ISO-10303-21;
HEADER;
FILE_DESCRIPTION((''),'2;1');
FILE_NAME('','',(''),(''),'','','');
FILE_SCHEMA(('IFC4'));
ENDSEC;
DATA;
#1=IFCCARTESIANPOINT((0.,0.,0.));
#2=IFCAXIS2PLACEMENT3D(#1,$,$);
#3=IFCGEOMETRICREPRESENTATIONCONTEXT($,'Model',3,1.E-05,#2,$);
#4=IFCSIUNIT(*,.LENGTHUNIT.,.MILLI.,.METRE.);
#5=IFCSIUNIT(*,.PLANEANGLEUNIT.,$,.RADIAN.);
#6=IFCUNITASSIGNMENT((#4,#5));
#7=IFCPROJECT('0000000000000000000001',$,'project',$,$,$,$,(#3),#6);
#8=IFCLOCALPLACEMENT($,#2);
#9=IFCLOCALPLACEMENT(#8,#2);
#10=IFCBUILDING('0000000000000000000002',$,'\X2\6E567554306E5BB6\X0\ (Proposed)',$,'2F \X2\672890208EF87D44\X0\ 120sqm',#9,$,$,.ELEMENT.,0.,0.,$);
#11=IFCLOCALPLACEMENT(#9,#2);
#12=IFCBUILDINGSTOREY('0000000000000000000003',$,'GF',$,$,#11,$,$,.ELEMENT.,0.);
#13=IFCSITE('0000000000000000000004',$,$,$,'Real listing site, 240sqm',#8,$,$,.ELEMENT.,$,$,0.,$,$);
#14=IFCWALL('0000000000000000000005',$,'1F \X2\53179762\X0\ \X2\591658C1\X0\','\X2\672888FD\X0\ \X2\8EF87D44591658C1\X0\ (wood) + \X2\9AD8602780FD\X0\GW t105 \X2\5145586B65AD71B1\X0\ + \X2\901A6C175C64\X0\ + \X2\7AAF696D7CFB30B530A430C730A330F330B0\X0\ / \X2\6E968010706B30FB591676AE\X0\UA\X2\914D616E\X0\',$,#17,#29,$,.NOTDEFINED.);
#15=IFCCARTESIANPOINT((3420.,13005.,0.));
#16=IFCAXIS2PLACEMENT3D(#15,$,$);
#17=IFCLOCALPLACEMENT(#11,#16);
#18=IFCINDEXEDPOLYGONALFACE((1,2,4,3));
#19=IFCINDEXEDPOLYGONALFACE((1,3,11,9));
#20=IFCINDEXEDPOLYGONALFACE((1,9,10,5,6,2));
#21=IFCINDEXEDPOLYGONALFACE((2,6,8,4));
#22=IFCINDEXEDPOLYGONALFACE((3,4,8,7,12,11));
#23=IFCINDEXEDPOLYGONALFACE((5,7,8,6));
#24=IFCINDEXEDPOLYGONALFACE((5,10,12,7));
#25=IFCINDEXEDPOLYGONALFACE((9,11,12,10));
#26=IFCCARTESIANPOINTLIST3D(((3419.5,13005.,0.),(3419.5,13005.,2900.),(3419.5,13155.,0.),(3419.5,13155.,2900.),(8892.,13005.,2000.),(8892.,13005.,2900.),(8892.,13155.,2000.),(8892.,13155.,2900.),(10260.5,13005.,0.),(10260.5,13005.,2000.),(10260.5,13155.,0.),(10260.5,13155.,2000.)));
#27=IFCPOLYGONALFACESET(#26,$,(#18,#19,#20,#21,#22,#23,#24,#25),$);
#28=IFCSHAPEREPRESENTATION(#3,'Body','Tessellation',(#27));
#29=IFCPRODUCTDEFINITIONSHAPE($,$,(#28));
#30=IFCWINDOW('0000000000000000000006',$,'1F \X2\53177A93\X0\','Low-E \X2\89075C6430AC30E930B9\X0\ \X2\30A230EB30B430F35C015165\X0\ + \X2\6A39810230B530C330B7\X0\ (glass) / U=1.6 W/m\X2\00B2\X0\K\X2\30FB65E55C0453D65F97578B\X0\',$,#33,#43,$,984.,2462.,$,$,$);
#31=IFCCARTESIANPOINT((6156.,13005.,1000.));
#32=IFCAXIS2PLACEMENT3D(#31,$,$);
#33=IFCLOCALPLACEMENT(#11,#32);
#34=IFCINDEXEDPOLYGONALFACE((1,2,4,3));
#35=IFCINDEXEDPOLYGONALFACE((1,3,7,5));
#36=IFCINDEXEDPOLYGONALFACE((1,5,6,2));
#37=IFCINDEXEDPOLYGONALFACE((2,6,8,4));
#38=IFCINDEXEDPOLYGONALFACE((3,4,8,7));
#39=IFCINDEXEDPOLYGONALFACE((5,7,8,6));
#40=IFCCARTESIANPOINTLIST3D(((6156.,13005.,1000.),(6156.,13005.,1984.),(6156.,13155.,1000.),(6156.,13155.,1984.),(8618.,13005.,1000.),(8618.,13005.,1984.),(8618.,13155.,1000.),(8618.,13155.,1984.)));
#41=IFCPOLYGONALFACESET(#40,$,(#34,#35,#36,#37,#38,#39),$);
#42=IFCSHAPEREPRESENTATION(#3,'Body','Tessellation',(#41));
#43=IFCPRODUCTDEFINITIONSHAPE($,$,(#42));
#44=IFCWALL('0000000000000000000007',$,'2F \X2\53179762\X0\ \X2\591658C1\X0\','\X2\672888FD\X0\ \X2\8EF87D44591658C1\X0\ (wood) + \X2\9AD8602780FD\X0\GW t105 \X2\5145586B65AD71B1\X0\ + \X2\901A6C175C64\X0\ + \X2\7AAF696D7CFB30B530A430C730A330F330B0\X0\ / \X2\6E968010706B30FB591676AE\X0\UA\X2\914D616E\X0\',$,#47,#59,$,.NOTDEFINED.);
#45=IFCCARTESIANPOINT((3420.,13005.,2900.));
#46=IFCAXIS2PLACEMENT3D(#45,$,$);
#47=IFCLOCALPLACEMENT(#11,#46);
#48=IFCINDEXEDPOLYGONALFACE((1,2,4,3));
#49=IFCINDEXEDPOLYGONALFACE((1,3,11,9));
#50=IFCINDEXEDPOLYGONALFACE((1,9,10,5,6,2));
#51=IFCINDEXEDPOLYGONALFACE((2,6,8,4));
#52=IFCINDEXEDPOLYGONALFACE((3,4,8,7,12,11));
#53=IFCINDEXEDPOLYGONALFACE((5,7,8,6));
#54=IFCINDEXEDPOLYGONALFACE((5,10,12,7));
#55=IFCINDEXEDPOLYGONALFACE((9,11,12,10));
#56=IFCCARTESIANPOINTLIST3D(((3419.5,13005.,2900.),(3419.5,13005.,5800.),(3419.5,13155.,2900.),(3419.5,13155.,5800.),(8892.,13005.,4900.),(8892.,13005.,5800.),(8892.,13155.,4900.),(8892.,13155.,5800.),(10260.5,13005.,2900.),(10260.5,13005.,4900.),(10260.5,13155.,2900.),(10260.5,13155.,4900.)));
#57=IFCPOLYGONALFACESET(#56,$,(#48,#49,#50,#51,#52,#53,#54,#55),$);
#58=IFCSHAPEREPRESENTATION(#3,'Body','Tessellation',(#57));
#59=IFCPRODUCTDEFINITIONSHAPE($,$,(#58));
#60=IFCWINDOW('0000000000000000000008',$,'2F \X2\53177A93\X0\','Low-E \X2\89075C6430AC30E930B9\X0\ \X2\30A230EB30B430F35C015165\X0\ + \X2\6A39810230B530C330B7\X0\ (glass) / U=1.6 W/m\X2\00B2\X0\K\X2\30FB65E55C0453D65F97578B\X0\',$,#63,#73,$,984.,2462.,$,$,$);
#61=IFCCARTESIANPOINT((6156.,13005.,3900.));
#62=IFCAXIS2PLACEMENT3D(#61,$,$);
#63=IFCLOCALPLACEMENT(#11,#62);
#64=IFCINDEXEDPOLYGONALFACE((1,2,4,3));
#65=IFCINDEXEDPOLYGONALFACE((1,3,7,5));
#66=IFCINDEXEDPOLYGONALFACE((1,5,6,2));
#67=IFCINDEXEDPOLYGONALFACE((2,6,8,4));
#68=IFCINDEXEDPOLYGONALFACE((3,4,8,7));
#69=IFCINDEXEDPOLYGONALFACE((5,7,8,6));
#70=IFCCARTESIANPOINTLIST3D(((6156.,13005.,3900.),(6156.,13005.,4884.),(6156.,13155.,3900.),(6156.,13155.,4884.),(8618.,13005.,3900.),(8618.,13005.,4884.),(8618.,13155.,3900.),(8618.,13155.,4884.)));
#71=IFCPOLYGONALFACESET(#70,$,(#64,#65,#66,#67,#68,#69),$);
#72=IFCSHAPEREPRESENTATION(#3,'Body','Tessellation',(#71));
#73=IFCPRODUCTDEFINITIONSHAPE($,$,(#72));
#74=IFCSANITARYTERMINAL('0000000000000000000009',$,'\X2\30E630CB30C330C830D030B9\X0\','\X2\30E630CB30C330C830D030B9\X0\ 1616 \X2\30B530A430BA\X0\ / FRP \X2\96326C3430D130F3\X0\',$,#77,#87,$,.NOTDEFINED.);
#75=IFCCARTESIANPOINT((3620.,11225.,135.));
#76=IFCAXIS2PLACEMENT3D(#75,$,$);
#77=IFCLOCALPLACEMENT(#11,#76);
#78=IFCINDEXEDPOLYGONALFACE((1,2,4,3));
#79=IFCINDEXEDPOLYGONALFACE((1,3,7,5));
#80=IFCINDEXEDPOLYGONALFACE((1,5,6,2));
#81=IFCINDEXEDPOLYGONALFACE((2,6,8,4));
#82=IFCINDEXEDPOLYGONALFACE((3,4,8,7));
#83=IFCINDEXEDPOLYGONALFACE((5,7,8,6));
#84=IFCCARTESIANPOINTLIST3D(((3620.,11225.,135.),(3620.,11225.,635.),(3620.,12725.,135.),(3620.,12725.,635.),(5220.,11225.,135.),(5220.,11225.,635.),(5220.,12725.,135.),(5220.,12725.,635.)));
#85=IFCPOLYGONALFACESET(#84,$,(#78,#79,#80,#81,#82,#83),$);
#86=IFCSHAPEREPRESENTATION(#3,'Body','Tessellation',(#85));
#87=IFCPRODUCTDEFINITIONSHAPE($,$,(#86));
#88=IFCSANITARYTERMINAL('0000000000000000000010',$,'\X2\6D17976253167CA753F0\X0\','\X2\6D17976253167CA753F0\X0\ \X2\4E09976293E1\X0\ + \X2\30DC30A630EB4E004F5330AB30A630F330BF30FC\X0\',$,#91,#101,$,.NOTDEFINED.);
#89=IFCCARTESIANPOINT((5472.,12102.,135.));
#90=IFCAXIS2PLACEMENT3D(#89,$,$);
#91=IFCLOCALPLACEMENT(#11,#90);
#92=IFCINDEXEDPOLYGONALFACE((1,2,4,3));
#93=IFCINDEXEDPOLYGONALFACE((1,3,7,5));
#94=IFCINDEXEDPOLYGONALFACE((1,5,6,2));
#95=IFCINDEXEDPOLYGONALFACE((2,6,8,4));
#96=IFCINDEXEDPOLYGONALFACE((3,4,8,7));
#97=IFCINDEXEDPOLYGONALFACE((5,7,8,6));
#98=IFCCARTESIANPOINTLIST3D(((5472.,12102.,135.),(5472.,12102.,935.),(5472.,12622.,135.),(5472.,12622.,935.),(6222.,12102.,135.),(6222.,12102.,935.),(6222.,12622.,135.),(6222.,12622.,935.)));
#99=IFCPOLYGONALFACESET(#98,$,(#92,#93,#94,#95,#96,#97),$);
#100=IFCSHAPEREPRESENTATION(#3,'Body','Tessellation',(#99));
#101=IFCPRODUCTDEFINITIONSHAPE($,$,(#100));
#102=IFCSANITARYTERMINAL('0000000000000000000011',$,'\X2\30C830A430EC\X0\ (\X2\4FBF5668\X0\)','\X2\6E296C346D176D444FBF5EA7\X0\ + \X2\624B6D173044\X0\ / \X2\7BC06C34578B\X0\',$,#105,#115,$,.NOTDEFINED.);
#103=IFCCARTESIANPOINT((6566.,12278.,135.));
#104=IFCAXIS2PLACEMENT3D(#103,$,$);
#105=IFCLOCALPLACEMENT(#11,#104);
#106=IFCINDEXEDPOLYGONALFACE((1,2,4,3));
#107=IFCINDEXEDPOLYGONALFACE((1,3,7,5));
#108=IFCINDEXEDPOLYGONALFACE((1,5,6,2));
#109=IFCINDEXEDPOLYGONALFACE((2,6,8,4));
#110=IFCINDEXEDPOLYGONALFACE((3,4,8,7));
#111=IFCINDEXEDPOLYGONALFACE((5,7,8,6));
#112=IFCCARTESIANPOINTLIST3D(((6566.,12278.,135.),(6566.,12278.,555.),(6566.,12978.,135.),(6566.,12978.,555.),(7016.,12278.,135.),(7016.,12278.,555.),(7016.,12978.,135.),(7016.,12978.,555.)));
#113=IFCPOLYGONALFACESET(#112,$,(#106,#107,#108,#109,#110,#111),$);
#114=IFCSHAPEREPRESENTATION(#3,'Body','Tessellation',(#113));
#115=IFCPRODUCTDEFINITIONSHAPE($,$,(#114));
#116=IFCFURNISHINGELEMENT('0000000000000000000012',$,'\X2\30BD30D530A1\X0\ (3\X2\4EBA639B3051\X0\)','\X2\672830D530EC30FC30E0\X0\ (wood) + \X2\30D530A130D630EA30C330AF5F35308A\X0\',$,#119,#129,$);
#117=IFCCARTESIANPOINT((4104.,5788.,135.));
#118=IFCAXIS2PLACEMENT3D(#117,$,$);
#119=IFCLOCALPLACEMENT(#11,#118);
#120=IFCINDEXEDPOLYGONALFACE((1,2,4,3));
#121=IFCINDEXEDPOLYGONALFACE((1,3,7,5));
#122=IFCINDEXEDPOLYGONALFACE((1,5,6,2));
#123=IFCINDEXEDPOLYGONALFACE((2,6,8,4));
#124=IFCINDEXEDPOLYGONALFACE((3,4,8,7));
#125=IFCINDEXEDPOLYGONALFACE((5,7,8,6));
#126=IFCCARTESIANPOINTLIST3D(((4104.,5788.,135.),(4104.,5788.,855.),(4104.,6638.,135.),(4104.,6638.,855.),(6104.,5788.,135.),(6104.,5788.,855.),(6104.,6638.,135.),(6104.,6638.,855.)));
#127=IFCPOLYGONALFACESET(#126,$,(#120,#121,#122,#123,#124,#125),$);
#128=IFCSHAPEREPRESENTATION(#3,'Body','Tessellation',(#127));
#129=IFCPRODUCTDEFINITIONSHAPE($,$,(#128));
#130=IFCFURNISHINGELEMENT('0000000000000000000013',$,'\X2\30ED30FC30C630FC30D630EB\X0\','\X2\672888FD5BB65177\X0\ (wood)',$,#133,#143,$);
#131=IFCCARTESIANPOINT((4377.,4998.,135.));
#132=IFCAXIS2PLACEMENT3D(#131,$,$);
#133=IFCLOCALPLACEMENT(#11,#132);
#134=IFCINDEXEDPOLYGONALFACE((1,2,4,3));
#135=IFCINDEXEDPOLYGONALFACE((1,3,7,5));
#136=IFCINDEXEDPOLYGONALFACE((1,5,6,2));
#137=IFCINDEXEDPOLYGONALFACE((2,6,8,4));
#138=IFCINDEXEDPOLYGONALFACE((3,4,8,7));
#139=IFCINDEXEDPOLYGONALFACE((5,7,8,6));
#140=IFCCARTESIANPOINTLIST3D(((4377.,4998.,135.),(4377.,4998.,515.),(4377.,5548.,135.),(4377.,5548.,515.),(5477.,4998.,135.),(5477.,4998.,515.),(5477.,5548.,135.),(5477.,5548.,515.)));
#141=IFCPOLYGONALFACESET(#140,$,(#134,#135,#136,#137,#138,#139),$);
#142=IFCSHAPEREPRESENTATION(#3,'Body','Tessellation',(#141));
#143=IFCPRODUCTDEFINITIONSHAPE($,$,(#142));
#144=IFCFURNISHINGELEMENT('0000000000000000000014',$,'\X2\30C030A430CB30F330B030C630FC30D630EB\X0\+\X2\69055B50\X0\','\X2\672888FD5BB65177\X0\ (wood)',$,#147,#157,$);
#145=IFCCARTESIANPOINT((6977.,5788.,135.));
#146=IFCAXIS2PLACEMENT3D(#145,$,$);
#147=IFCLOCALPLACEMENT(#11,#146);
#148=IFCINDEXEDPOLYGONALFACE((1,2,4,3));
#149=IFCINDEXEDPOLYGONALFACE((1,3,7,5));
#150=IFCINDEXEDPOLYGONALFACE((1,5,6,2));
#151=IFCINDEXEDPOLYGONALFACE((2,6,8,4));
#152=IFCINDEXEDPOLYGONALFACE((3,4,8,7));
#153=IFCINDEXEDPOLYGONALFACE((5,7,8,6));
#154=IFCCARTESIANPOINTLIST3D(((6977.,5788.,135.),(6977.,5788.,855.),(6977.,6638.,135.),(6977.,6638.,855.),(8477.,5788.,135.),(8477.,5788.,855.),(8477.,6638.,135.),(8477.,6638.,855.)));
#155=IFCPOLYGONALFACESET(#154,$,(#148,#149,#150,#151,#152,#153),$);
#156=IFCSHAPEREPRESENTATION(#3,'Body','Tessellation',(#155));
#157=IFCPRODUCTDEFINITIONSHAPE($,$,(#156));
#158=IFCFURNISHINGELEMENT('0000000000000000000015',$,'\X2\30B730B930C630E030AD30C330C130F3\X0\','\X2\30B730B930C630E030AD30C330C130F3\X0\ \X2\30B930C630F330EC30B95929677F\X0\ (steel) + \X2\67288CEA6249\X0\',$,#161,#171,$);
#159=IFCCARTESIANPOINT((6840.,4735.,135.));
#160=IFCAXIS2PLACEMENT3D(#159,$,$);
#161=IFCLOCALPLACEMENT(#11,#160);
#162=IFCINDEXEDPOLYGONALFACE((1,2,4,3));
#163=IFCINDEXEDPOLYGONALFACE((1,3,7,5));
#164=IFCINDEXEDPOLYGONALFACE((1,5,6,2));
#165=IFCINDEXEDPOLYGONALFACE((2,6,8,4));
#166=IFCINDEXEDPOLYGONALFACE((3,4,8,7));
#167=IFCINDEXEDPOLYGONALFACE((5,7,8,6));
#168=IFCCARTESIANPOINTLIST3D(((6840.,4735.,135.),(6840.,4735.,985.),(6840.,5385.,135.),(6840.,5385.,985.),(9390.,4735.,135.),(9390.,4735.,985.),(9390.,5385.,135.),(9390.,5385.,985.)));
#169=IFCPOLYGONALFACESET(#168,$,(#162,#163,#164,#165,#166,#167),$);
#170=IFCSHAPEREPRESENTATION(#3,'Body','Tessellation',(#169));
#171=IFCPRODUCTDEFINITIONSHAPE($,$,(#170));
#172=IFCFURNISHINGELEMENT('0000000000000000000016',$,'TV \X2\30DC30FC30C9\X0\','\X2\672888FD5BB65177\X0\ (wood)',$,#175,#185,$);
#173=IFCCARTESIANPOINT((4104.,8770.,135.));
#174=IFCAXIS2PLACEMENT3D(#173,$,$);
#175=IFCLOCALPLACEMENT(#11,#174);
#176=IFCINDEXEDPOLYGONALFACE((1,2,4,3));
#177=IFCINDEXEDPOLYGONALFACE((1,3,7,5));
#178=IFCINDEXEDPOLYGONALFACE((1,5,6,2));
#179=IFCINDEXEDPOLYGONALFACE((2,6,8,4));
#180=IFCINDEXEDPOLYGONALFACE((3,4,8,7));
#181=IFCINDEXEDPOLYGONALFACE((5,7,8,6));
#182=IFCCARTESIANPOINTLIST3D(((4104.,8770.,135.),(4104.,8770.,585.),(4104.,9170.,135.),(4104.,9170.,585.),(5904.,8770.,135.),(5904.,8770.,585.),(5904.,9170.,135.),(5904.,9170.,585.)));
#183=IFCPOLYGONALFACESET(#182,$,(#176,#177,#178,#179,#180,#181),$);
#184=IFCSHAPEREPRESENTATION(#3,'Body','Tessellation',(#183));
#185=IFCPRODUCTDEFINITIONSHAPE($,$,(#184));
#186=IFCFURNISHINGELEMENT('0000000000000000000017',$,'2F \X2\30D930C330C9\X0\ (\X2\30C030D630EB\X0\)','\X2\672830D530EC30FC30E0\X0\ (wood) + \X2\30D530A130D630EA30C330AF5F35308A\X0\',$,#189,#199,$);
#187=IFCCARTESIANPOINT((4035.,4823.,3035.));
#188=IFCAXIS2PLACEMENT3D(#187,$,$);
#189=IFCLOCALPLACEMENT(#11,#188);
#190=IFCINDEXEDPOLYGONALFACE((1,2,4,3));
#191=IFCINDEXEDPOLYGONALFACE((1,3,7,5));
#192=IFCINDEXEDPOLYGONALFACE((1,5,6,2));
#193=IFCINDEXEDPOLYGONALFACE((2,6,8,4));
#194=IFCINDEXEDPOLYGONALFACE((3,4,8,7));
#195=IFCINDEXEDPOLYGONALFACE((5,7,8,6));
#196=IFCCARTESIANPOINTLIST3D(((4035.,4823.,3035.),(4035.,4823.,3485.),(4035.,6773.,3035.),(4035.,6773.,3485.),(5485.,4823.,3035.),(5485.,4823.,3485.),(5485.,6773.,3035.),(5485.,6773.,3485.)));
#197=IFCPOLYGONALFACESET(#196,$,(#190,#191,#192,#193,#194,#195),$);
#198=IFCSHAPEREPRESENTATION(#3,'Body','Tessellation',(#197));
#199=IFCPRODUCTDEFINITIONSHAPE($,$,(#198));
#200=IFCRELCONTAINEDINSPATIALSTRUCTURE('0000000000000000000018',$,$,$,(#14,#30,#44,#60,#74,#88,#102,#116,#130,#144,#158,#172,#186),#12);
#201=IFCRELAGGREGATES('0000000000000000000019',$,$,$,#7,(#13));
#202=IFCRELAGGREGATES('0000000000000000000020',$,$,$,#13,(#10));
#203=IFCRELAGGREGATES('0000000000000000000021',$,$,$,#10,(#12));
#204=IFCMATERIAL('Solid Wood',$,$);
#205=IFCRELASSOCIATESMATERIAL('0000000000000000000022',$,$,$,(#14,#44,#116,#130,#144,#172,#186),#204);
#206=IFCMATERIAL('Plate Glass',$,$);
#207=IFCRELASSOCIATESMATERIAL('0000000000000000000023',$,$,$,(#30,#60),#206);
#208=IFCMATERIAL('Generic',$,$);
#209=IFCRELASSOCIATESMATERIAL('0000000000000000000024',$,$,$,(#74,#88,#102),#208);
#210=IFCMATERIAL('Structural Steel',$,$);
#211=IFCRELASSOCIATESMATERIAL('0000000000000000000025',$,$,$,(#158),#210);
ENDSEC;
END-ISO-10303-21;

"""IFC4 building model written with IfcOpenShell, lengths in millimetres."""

from ifc_helpers import new_model, si_unit, frame, frame_2d, origin, place, context, project, spatial, rectangle, extrude, material, element, fill, save


model = new_model("IFC4")

# Units and contexts
model_context = context("Model", 3, precision=1e-05, world=origin())
ifc_project = project(units=[si_unit("LENGTHUNIT", "METRE", prefix="MILLI"), si_unit("PLANEANGLEUNIT", "RADIAN")], contexts=[model_context])

# Site, building, storey
site_placement = place(None, origin())
site = spatial("IfcSite", under=ifc_project, at=site_placement, ObjectType="Real listing site, 240sqm", CompositionType="ELEMENT", RefElevation=0.0)
building_placement = place(site_placement, origin())
building = spatial("IfcBuilding", under=site, at=building_placement, Name="湖畔の家 (Proposed)", ObjectType="2F 木造軸組 120sqm", CompositionType="ELEMENT", ElevationOfRefHeight=0.0, ElevationOfTerrain=0.0)
storey_placement = place(building_placement, origin())
storey = spatial("IfcBuildingStorey", under=building, at=storey_placement, Name="GF", CompositionType="ELEMENT", Elevation=0.0)

# Wall, opening, window
ifc_material_1 = material(Name="Solid Wood")
wall_1_placement = place(storey_placement, frame((3420.0, 13005.0, 0.0)))
wall_1 = element("IfcWall", 1, at=wall_1_placement, inside=storey, material=ifc_material_1, Name="1F 北面 外壁", Description="木製 軸組外壁 (wood) + 高性能GW t105 充填断熱 + 通気層 + 窯業系サイディング / 準耐火・外皮UA配慮", PredefinedType="NOTDEFINED", context=model_context, shape_type="SweptSolid", body=[
    extrude(rectangle(XDim=6841.0, YDim=150.0, at=frame_2d((3420.0, 75.0))), frame((3420.0, 13005.0, 0.0)), (0.0, 0.0, 1.0), 2900.0),
])
opening_1_placement = place(storey_placement, frame((6156.0, 13005.0, 1000.0)))
opening_1 = element("IfcOpeningElement", 2, at=opening_1_placement, cuts=wall_1, PredefinedType="NOTDEFINED", context=model_context, shape_type="SweptSolid", body=[
    extrude(rectangle(XDim=2462.0, YDim=150.0, at=frame_2d((1231.0, 75.0))), frame((6156.0, 13005.0, 1000.0)), (0.0, 0.0, 1.0), 984.0),
])
ifc_material_2 = material(Name="Plate Glass")
window_1_placement = place(storey_placement, frame((6156.0, 13005.0, 1000.0)))
window_1 = element("IfcWindow", 3, at=window_1_placement, inside=storey, material=ifc_material_2, Name="1F 北窓", Description="Low-E 複層ガラス アルゴン封入 + 樹脂サッシ (glass) / U=1.6 W/m²K・日射取得型", OverallHeight=984.0, OverallWidth=2462.0, context=model_context, shape_type="SweptSolid", body=[
    extrude(rectangle(XDim=2462.0, YDim=150.0, at=frame_2d((1231.0, 75.0))), frame((6156.0, 13005.0, 1000.0)), (0.0, 0.0, 1.0), 984.0),
])
fill(opening_1, window_1)

# Wall, opening, window
wall_2_placement = place(storey_placement, frame((3420.0, 13005.0, 2900.0)))
wall_2 = element("IfcWall", 4, at=wall_2_placement, inside=storey, material=ifc_material_1, Name="2F 北面 外壁", Description="木製 軸組外壁 (wood) + 高性能GW t105 充填断熱 + 通気層 + 窯業系サイディング / 準耐火・外皮UA配慮", PredefinedType="NOTDEFINED", context=model_context, shape_type="SweptSolid", body=[
    extrude(rectangle(XDim=6841.0, YDim=150.0, at=frame_2d((3420.0, 75.0))), frame((3420.0, 13005.0, 2900.0)), (0.0, 0.0, 1.0), 2900.0),
])
opening_2_placement = place(storey_placement, frame((6156.0, 13005.0, 3900.0)))
opening_2 = element("IfcOpeningElement", 5, at=opening_2_placement, cuts=wall_2, PredefinedType="NOTDEFINED", context=model_context, shape_type="SweptSolid", body=[
    extrude(rectangle(XDim=2462.0, YDim=150.0, at=frame_2d((1231.0, 75.0))), frame((6156.0, 13005.0, 3900.0)), (0.0, 0.0, 1.0), 984.0),
])
window_2_placement = place(storey_placement, frame((6156.0, 13005.0, 3900.0)))
window_2 = element("IfcWindow", 6, at=window_2_placement, inside=storey, material=ifc_material_2, Name="2F 北窓", Description="Low-E 複層ガラス アルゴン封入 + 樹脂サッシ (glass) / U=1.6 W/m²K・日射取得型", OverallHeight=984.0, OverallWidth=2462.0, context=model_context, shape_type="SweptSolid", body=[
    extrude(rectangle(XDim=2462.0, YDim=150.0, at=frame_2d((1231.0, 75.0))), frame((6156.0, 13005.0, 3900.0)), (0.0, 0.0, 1.0), 984.0),
])
fill(opening_2, window_2)

# Sanitary terminals
ifc_material_3 = material(Name="Generic")
sanitary_terminal_1_placement = place(storey_placement, frame((3620.0, 11225.0, 135.0)))
element("IfcSanitaryTerminal", 7, at=sanitary_terminal_1_placement, inside=storey, material=ifc_material_3, Name="ユニットバス", Description="ユニットバス 1616 サイズ / FRP 防水パン", PredefinedType="NOTDEFINED", context=model_context, shape_type="SweptSolid", body=[
    extrude(rectangle(XDim=1600.0, YDim=1500.0, at=frame_2d((800.0, 750.0))), frame((3620.0, 11225.0, 135.0)), (0.0, 0.0, 1.0), 500.0),
])
sanitary_terminal_2_placement = place(storey_placement, frame((5472.0, 12102.0, 135.0)))
element("IfcSanitaryTerminal", 8, at=sanitary_terminal_2_placement, inside=storey, material=ifc_material_3, Name="洗面化粧台", Description="洗面化粧台 三面鏡 + ボウル一体カウンター", PredefinedType="NOTDEFINED", context=model_context, shape_type="SweptSolid", body=[
    extrude(rectangle(XDim=750.0, YDim=520.0, at=frame_2d((375.0, 260.0))), frame((5472.0, 12102.0, 135.0)), (0.0, 0.0, 1.0), 800.0),
])
sanitary_terminal_3_placement = place(storey_placement, frame((6566.0, 12278.0, 135.0)))
element("IfcSanitaryTerminal", 9, at=sanitary_terminal_3_placement, inside=storey, material=ifc_material_3, Name="トイレ (便器)", Description="温水洗浄便座 + 手洗い / 節水型", PredefinedType="NOTDEFINED", context=model_context, shape_type="SweptSolid", body=[
    extrude(rectangle(XDim=450.0, YDim=700.0, at=frame_2d((225.0, 350.0))), frame((6566.0, 12278.0, 135.0)), (0.0, 0.0, 1.0), 420.0),
])

# Furnishing elements
furnishing_1_placement = place(storey_placement, frame((4104.0, 5788.0, 135.0)))
element("IfcFurnishingElement", 10, at=furnishing_1_placement, inside=storey, material=ifc_material_1, Name="ソファ (3人掛け)", Description="木フレーム (wood) + ファブリック張り", context=model_context, shape_type="SweptSolid", body=[
    extrude(rectangle(XDim=2000.0, YDim=850.0, at=frame_2d((1000.0, 425.0))), frame((4104.0, 5788.0, 135.0)), (0.0, 0.0, 1.0), 720.0),
])
furnishing_2_placement = place(storey_placement, frame((4377.0, 4998.0, 135.0)))
element("IfcFurnishingElement", 11, at=furnishing_2_placement, inside=storey, material=ifc_material_1, Name="ローテーブル", Description="木製家具 (wood)", context=model_context, shape_type="SweptSolid", body=[
    extrude(rectangle(XDim=1100.0, YDim=550.0, at=frame_2d((550.0, 275.0))), frame((4377.0, 4998.0, 135.0)), (0.0, 0.0, 1.0), 380.0),
])
furnishing_3_placement = place(storey_placement, frame((6977.0, 5788.0, 135.0)))
element("IfcFurnishingElement", 12, at=furnishing_3_placement, inside=storey, material=ifc_material_1, Name="ダイニングテーブル+椅子", Description="木製家具 (wood)", context=model_context, shape_type="SweptSolid", body=[
    extrude(rectangle(XDim=1500.0, YDim=850.0, at=frame_2d((750.0, 425.0))), frame((6977.0, 5788.0, 135.0)), (0.0, 0.0, 1.0), 720.0),
])
ifc_material_4 = material(Name="Structural Steel")
furnishing_4_placement = place(storey_placement, frame((6840.0, 4735.0, 135.0)))
element("IfcFurnishingElement", 13, at=furnishing_4_placement, inside=storey, material=ifc_material_4, Name="システムキッチン", Description="システムキッチン ステンレス天板 (steel) + 木質扉", context=model_context, shape_type="SweptSolid", body=[
    extrude(rectangle(XDim=2550.0, YDim=650.0, at=frame_2d((1275.0, 325.0))), frame((6840.0, 4735.0, 135.0)), (0.0, 0.0, 1.0), 850.0),
])
furnishing_5_placement = place(storey_placement, frame((4104.0, 8770.0, 135.0)))
element("IfcFurnishingElement", 14, at=furnishing_5_placement, inside=storey, material=ifc_material_1, Name="TV ボード", Description="木製家具 (wood)", context=model_context, shape_type="SweptSolid", body=[
    extrude(rectangle(XDim=1800.0, YDim=400.0, at=frame_2d((900.0, 200.0))), frame((4104.0, 8770.0, 135.0)), (0.0, 0.0, 1.0), 450.0),
])
furnishing_6_placement = place(storey_placement, frame((4035.0, 4823.0, 3035.0)))
element("IfcFurnishingElement", 15, at=furnishing_6_placement, inside=storey, material=ifc_material_1, Name="2F ベッド (ダブル)", Description="木フレーム (wood) + ファブリック張り", context=model_context, shape_type="SweptSolid", body=[
    extrude(rectangle(XDim=1450.0, YDim=1950.0, at=frame_2d((725.0, 975.0))), frame((4035.0, 4823.0, 3035.0)), (0.0, 0.0, 1.0), 450.0),
])

save(model, "model.ifc")
